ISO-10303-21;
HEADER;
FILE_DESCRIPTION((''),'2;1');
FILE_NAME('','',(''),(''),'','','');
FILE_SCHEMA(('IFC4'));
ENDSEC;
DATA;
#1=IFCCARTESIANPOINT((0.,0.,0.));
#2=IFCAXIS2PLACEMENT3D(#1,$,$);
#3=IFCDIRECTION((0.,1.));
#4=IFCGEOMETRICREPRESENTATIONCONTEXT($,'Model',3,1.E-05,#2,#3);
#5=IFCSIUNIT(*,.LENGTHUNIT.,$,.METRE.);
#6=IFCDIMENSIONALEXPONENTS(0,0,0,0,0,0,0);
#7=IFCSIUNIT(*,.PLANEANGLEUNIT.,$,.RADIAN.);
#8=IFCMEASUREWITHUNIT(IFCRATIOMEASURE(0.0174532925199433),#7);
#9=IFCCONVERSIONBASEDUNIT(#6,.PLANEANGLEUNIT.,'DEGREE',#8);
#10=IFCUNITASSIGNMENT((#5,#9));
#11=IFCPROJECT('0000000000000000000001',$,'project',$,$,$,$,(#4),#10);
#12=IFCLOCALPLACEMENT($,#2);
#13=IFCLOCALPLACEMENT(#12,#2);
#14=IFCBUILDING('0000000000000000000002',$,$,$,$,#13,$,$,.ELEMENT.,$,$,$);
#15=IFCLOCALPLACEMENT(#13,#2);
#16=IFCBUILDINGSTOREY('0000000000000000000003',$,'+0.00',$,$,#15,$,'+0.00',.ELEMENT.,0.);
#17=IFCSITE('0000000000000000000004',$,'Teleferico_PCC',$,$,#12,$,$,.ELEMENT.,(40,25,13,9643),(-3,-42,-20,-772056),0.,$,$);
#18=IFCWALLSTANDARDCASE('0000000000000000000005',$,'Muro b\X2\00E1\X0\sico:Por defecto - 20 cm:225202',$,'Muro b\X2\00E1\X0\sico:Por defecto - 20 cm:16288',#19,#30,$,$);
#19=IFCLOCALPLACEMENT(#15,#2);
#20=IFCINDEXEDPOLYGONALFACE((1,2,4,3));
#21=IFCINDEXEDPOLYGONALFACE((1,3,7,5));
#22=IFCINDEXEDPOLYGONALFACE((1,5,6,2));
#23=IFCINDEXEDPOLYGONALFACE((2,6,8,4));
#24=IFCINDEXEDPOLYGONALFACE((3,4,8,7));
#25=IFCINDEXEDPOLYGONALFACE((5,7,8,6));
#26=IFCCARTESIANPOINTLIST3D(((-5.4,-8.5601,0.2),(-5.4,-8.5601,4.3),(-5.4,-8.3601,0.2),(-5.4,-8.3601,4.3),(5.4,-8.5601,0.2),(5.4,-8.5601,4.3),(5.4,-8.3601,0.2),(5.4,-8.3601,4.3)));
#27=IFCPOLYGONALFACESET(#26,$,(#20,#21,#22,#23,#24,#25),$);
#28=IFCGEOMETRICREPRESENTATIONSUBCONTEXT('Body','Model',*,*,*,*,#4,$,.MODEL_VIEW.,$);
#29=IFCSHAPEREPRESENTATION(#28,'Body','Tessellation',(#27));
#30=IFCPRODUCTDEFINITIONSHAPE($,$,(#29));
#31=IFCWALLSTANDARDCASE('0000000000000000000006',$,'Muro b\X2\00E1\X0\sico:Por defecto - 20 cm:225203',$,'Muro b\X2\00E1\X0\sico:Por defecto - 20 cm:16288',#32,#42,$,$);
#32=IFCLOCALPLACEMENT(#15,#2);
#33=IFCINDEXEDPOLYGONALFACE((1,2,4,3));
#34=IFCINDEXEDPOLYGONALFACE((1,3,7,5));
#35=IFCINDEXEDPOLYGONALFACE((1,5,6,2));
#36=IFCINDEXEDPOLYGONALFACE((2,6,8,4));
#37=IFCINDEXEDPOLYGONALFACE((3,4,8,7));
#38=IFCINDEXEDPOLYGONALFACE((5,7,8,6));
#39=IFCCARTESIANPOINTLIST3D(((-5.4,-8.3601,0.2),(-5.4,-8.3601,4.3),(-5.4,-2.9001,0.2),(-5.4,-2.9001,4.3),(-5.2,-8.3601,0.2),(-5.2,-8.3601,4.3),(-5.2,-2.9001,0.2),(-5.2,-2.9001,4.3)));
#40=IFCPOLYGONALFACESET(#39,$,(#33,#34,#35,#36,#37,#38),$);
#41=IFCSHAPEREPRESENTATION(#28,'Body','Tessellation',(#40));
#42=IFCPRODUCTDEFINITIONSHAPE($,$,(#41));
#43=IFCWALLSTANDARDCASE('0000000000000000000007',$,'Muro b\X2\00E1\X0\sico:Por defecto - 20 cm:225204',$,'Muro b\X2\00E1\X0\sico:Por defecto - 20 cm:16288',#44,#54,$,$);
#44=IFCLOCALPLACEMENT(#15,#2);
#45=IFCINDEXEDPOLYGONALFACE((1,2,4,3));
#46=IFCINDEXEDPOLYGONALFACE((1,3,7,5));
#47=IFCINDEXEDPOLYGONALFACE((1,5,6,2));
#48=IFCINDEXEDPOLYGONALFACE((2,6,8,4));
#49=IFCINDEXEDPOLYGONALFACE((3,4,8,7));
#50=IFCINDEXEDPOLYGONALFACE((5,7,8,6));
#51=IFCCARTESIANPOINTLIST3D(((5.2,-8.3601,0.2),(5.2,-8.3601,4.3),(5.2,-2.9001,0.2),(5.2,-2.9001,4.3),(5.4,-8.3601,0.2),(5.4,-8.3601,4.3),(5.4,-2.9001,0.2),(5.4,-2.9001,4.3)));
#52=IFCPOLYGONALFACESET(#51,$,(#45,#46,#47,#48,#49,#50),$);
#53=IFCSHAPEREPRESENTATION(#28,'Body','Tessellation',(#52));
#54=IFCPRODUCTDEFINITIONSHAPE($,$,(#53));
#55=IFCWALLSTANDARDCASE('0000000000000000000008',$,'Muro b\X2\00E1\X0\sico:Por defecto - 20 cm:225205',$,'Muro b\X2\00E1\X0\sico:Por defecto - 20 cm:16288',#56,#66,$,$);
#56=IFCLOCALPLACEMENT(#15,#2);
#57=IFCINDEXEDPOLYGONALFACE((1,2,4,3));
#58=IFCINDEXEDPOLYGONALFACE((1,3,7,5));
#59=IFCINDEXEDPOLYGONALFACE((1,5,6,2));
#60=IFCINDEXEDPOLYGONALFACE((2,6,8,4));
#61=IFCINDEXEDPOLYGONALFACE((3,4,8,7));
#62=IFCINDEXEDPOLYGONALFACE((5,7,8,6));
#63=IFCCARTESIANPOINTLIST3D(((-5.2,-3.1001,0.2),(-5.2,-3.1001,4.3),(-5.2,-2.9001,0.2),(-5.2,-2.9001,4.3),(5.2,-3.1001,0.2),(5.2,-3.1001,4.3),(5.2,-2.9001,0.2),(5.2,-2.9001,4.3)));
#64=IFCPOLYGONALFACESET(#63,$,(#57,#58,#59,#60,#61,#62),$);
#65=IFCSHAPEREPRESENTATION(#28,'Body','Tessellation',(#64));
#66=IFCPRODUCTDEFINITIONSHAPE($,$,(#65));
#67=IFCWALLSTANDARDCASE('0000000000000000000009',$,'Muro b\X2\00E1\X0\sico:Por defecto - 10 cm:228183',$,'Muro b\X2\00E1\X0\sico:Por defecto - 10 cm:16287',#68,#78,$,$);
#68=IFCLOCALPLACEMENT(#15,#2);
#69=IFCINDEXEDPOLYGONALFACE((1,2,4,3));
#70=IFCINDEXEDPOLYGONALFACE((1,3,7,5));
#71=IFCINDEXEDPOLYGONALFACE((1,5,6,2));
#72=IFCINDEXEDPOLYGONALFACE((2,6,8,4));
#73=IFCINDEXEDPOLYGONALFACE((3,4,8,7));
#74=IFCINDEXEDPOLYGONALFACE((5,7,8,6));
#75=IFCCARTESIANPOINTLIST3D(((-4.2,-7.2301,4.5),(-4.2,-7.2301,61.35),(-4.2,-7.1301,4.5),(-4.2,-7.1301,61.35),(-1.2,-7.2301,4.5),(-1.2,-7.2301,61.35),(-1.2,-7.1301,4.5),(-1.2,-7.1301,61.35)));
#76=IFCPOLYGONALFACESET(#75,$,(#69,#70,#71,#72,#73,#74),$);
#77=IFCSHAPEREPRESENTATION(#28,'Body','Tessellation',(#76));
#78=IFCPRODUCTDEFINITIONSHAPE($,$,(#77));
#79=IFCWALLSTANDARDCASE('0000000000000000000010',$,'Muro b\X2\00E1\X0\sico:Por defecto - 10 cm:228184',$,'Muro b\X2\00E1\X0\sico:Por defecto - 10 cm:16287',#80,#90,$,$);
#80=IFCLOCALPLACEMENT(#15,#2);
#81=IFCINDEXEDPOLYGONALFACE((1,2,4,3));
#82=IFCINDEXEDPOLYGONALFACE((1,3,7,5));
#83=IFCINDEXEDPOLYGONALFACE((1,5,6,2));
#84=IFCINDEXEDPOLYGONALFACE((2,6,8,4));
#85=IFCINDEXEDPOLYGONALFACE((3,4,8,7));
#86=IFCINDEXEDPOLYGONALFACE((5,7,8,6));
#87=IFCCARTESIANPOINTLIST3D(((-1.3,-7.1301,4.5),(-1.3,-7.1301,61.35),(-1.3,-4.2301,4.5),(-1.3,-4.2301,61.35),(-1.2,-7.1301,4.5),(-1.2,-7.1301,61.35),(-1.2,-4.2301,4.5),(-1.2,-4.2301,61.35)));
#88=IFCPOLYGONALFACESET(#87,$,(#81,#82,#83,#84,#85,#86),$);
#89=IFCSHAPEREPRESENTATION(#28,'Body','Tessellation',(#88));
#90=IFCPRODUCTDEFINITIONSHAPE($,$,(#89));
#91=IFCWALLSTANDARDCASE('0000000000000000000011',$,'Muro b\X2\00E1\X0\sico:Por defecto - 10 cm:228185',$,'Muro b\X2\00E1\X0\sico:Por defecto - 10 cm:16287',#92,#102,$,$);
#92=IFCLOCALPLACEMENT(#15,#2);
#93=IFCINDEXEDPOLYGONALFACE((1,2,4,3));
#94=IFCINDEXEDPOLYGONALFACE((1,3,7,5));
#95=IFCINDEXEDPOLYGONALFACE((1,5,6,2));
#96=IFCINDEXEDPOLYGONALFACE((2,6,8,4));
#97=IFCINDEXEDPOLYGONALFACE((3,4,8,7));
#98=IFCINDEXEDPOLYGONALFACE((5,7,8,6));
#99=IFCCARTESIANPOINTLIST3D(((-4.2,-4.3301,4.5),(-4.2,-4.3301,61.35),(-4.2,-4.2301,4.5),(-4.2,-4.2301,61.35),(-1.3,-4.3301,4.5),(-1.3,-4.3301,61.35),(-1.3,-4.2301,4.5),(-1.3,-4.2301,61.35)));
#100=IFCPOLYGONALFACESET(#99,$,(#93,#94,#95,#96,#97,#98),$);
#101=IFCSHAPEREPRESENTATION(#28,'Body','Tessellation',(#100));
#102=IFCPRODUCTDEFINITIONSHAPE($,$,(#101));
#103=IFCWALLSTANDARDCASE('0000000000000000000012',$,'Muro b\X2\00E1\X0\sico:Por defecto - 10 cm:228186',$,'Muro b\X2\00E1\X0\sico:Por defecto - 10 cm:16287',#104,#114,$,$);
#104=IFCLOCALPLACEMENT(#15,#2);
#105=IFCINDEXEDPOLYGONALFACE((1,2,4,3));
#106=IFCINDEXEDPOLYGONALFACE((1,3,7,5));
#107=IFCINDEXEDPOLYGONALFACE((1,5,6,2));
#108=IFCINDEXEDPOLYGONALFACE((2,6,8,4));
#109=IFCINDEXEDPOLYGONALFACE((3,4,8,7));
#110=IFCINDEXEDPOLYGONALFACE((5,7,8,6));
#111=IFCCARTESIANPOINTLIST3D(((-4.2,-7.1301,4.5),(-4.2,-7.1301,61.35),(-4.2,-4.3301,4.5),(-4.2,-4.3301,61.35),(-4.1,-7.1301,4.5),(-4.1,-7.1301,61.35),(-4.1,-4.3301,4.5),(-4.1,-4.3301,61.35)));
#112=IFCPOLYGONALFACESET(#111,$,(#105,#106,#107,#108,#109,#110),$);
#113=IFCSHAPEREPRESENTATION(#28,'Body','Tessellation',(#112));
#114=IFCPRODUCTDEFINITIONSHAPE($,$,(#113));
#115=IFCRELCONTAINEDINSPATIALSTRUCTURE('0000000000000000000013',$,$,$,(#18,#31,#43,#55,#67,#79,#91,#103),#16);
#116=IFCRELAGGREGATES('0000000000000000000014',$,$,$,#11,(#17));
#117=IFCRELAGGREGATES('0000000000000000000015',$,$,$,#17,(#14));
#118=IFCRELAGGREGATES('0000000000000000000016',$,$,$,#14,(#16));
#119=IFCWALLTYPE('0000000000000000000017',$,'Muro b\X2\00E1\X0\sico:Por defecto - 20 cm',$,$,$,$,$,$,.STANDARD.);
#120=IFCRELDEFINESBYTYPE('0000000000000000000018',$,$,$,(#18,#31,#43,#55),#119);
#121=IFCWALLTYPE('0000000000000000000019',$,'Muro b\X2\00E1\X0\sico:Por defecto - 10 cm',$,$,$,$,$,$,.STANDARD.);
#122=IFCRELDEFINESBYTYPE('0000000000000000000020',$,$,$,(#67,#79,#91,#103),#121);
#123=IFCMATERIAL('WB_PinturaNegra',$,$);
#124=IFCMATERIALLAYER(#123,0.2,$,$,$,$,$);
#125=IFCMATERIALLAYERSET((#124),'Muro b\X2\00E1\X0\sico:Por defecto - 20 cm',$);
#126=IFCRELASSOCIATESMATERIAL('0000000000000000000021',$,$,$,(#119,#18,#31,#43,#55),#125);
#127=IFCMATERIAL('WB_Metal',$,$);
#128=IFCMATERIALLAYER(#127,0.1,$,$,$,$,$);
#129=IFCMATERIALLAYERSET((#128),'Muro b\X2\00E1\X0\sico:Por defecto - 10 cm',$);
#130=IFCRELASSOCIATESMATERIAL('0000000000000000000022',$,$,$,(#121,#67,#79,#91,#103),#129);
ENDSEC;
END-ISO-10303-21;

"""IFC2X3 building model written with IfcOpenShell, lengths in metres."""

from ifc_helpers import new_model, entity, si_unit, converted_unit, direction, frame, frame_2d, origin, place, context, subcontext, project, spatial, polyline, rectangle, extrude, clip, bounded_halfspace, material, layer, layer_set, layer_usage, type_object, element, save


model = new_model("IFC2X3")

# Units and contexts
model_context = context("Model", 3, precision=1e-05, world=origin(), true_north=direction((0.0, 1.0)))
body_context = subcontext(model_context, "Body", "Model", "MODEL_VIEW")
ifc_project = project(units=[si_unit("LENGTHUNIT", "METRE"), converted_unit("PLANEANGLEUNIT", "DEGREE", entity("IfcRatioMeasure", 0.0174532925199433), si_unit("PLANEANGLEUNIT", "RADIAN"), dimensions=[0, 0, 0, 0, 0, 0, 0])], contexts=[model_context])

# Site, building, storey
site_placement = place(None, origin())
site = spatial("IfcSite", under=ifc_project, at=site_placement, Name="Teleferico_PCC", CompositionType="ELEMENT", RefLatitude=(40, 25, 13, 9643), RefLongitude=(-3, -42, -20, -772056), RefElevation=0.0)
building_placement = place(site_placement, origin())
building = spatial("IfcBuilding", under=site, at=building_placement, CompositionType="ELEMENT")
storey_placement = place(building_placement, origin())
storey = spatial("IfcBuildingStorey", under=building, at=storey_placement, Name="+0.00", LongName="+0.00", CompositionType="ELEMENT", Elevation=0.0)

# Shared definitions
ifc_material_1 = material(Name="WB_Metal")

# Shared definitions
ifc_material_2 = material(Name="WB_PinturaNegra")

# Walls
ifc_layer_1 = layer(ifc_material_2, 0.2)
ifc_layer_set_1 = layer_set([ifc_layer_1], Name="Muro básico:Por defecto - 20 cm")
ifc_layer_usage_1 = layer_usage(ifc_layer_set_1, "AXIS2", "POSITIVE", -0.1)
wall_type_1 = type_object("IfcWallType", Name="Muro básico:Por defecto - 20 cm", PredefinedType="STANDARD", material=ifc_layer_set_1)
wall_1_placement = place(storey_placement, frame((-5.4, -8.4601, 0.2)))
element("IfcWallStandardCase", 1, at=wall_1_placement, inside=storey, type_object=wall_type_1, material=ifc_layer_usage_1, Name="Muro básico:Por defecto - 20 cm:225202", ObjectType="Muro básico:Por defecto - 20 cm:16288", context=body_context, shape_type="Clipping", body=[
    clip(clip(extrude(rectangle(XDim=10.8, YDim=0.2, at=frame_2d((5.4, 0.0), x_axis=(-1.0, 0.0))), origin(), (0.0, 0.0, 1.0), 4.1), bounded_halfspace(frame((0.0, -0.1, 4.1), z_axis=(0.0, 0.0, -1.0), x_axis=(0.0, -1.0, 0.0)), True, frame((0.0, -0.1, 4.1), z_axis=(0.0, 0.0, -1.0), x_axis=(0.0, -1.0, 0.0)), polyline([(0.0, 0.0), (-0.2, 0.0), (-0.2, -0.2), (-0.2, -10.6), (-0.2, -10.8), (0.0, -10.8), (0.0, 0.0)]))), bounded_halfspace(frame((10.8, -0.1, 0.0), z_axis=(0.0, 0.0, 1.0), x_axis=(0.0, 1.0, 0.0)), True, frame((10.8, -0.1, 0.0), z_axis=(0.0, 0.0, 1.0), x_axis=(0.0, 1.0, 0.0)), polyline([(0.0, 0.0), (0.2, 0.0), (0.2, 0.2), (0.2, 10.6), (0.2, 10.8), (0.0, 10.8), (0.0, 0.0)]))),
])
ifc_layer_usage_2 = layer_usage(ifc_layer_set_1, "AXIS2", "POSITIVE", -0.1)
wall_2_placement = place(storey_placement, frame((-5.3, -2.9001, 0.2), z_axis=(0.0, 0.0, 1.0), x_axis=(0.0, -1.0, 0.0)))
element("IfcWallStandardCase", 2, at=wall_2_placement, inside=storey, type_object=wall_type_1, material=ifc_layer_usage_2, Name="Muro básico:Por defecto - 20 cm:225203", ObjectType="Muro básico:Por defecto - 20 cm:16288", context=body_context, shape_type="Clipping", body=[
    clip(clip(extrude(rectangle(XDim=5.46, YDim=0.2, at=frame_2d((2.73, 0.0), x_axis=(-1.0, 0.0))), origin(), (0.0, 0.0, 1.0), 4.1), bounded_halfspace(frame((0.0, -0.1, 4.1), z_axis=(0.0, 0.0, -1.0), x_axis=(1.0, 0.0, 0.0)), True, frame((0.0, -0.1, 4.1), z_axis=(0.0, 0.0, -1.0), x_axis=(1.0, 0.0, 0.0)), polyline([(0.0, 0.0), (0.0, -0.2), (0.2, -0.2), (5.46, -0.2), (5.46, 0.0), (0.0, 0.0)]))), bounded_halfspace(frame((5.46, -0.1, 0.0), z_axis=(0.0, 0.0, 1.0), x_axis=(-1.0, 0.0, 0.0)), True, frame((5.46, -0.1, 0.0), z_axis=(0.0, 0.0, 1.0), x_axis=(-1.0, 0.0, 0.0)), polyline([(0.0, 0.0), (0.0, -0.2), (5.26, -0.2), (5.46, -0.2), (5.46, 0.0), (0.0, 0.0)]))),
])
ifc_layer_usage_3 = layer_usage(ifc_layer_set_1, "AXIS2", "POSITIVE", -0.1)
wall_3_placement = place(storey_placement, frame((5.3, -8.3601, 0.2), z_axis=(0.0, 0.0, 1.0), x_axis=(0.0, 1.0, 0.0)))
element("IfcWallStandardCase", 3, at=wall_3_placement, inside=storey, type_object=wall_type_1, material=ifc_layer_usage_3, Name="Muro básico:Por defecto - 20 cm:225204", ObjectType="Muro básico:Por defecto - 20 cm:16288", context=body_context, shape_type="Clipping", body=[
    clip(clip(extrude(rectangle(XDim=5.46, YDim=0.2, at=frame_2d((2.73, 0.0), x_axis=(-1.0, 0.0))), origin(), (0.0, 0.0, 1.0), 4.1), bounded_halfspace(frame((0.0, -0.1, 4.1), z_axis=(0.0, 0.0, -1.0), x_axis=(-1.0, 0.0, 0.0)), True, frame((0.0, -0.1, 4.1), z_axis=(0.0, 0.0, -1.0), x_axis=(-1.0, 0.0, 0.0)), polyline([(0.0, 0.0), (0.0, 0.2), (-5.26, 0.2), (-5.46, 0.2), (-5.46, 0.0), (0.0, 0.0)]))), bounded_halfspace(frame((5.46, -0.1, 0.0)), True, frame((5.46, -0.1, 0.0)), polyline([(0.0, 0.0), (0.0, 0.2), (-0.2, 0.2), (-5.46, 0.2), (-5.46, 0.0), (0.0, 0.0)]))),
])
ifc_layer_usage_4 = layer_usage(ifc_layer_set_1, "AXIS2", "POSITIVE", -0.1)
wall_4_placement = place(storey_placement, frame((5.2, -3.0001, 0.2), z_axis=(0.0, 0.0, 1.0), x_axis=(-1.0, 0.0, 0.0)))
element("IfcWallStandardCase", 4, at=wall_4_placement, inside=storey, type_object=wall_type_1, material=ifc_layer_usage_4, Name="Muro básico:Por defecto - 20 cm:225205", ObjectType="Muro básico:Por defecto - 20 cm:16288", context=body_context, shape_type="Clipping", body=[
    clip(clip(extrude(rectangle(XDim=10.4, YDim=0.2, at=frame_2d((5.2, 0.0), x_axis=(-1.0, 0.0))), origin(), (0.0, 0.0, 1.0), 4.1), bounded_halfspace(frame((0.0, -0.1, 4.1), z_axis=(0.0, 0.0, -1.0), x_axis=(0.0, 1.0, 0.0)), True, frame((0.0, -0.1, 4.1), z_axis=(0.0, 0.0, -1.0), x_axis=(0.0, 1.0, 0.0)), polyline([(0.0, 0.0), (0.2, 0.0), (0.2, 10.4), (0.0, 10.4), (0.0, 0.0)]))), bounded_halfspace(frame((10.4, -0.1, 0.0), z_axis=(0.0, 0.0, 1.0), x_axis=(0.0, -1.0, 0.0)), True, frame((10.4, -0.1, 0.0), z_axis=(0.0, 0.0, 1.0), x_axis=(0.0, -1.0, 0.0)), polyline([(0.0, 0.0), (-0.2, 0.0), (-0.2, -10.4), (0.0, -10.4), (0.0, 0.0)]))),
])
ifc_layer_2 = layer(ifc_material_1, 0.1)
ifc_layer_set_2 = layer_set([ifc_layer_2], Name="Muro básico:Por defecto - 10 cm")
ifc_layer_usage_5 = layer_usage(ifc_layer_set_2, "AXIS2", "POSITIVE", -0.05)
wall_type_2 = type_object("IfcWallType", Name="Muro básico:Por defecto - 10 cm", PredefinedType="STANDARD", material=ifc_layer_set_2)
wall_5_placement = place(storey_placement, frame((-4.2, -7.1801, 4.5)))
element("IfcWallStandardCase", 5, at=wall_5_placement, inside=storey, type_object=wall_type_2, material=ifc_layer_usage_5, Name="Muro básico:Por defecto - 10 cm:228183", ObjectType="Muro básico:Por defecto - 10 cm:16287", context=body_context, shape_type="Clipping", body=[
    clip(extrude(rectangle(XDim=3.0, YDim=0.1, at=frame_2d((1.5, 0.0), x_axis=(-1.0, 0.0))), origin(), (0.0, 0.0, 1.0), 56.85), bounded_halfspace(frame((0.0, -0.05, 56.85), z_axis=(0.0, 0.0, -1.0), x_axis=(1.0, 0.0, 0.0)), True, frame((0.0, -0.05, 56.85)), polyline([(0.0, 0.0), (0.15, 0.0), (2.85, 0.0), (3.0, 0.0), (3.0, 0.1), (2.9, 0.1), (2.85, 0.1), (0.15, 0.1), (0.1, 0.1), (0.0, 0.1), (0.0, 0.0)]))),
])
ifc_layer_usage_6 = layer_usage(ifc_layer_set_2, "AXIS2", "POSITIVE", -0.05)
wall_6_placement = place(storey_placement, frame((-1.25, -7.1301, 4.5), z_axis=(0.0, 0.0, 1.0), x_axis=(0.0, 1.0, 0.0)))
element("IfcWallStandardCase", 6, at=wall_6_placement, inside=storey, type_object=wall_type_2, material=ifc_layer_usage_6, Name="Muro básico:Por defecto - 10 cm:228184", ObjectType="Muro básico:Por defecto - 10 cm:16287", context=body_context, shape_type="Clipping", body=[
    clip(extrude(rectangle(XDim=2.9, YDim=0.1, at=frame_2d((1.45, 0.0), x_axis=(-1.0, 0.0))), origin(), (0.0, 0.0, 1.0), 56.85), bounded_halfspace(frame((0.0, -0.05, 56.85), z_axis=(0.0, 0.0, -1.0), x_axis=(0.0, -1.0, 0.0)), True, frame((0.0, -0.05, 56.85)), polyline([(0.0, 0.0), (0.05, 0.0), (2.75, 0.0), (2.9, 0.0), (2.9, 0.1), (2.8, 0.1), (2.75, 0.1), (0.05, 0.1), (0.0, 0.1), (0.0, 0.0)]))),
])
ifc_layer_usage_7 = layer_usage(ifc_layer_set_2, "AXIS2", "POSITIVE", -0.05)
wall_7_placement = place(storey_placement, frame((-1.3, -4.2801, 4.5), z_axis=(0.0, 0.0, 1.0), x_axis=(-1.0, 0.0, 0.0)))
element("IfcWallStandardCase", 7, at=wall_7_placement, inside=storey, type_object=wall_type_2, material=ifc_layer_usage_7, Name="Muro básico:Por defecto - 10 cm:228185", ObjectType="Muro básico:Por defecto - 10 cm:16287", context=body_context, shape_type="Clipping", body=[
    clip(extrude(rectangle(XDim=2.9, YDim=0.1, at=frame_2d((1.45, 0.0), x_axis=(-1.0, 0.0))), origin(), (0.0, 0.0, 1.0), 56.85), bounded_halfspace(frame((0.0, -0.05, 56.85), z_axis=(0.0, 0.0, -1.0), x_axis=(-1.0, 0.0, 0.0)), True, frame((0.0, -0.05, 56.85)), polyline([(0.0, 0.0), (0.05, 0.0), (2.75, 0.0), (2.9, 0.0), (2.9, 0.1), (2.8, 0.1), (2.75, 0.1), (0.05, 0.1), (0.0, 0.1), (0.0, 0.0)]))),
])
ifc_layer_usage_8 = layer_usage(ifc_layer_set_2, "AXIS2", "POSITIVE", -0.05)
wall_8_placement = place(storey_placement, frame((-4.15, -4.3301, 4.5), z_axis=(0.0, 0.0, 1.0), x_axis=(0.0, -1.0, 0.0)))
element("IfcWallStandardCase", 8, at=wall_8_placement, inside=storey, type_object=wall_type_2, material=ifc_layer_usage_8, Name="Muro básico:Por defecto - 10 cm:228186", ObjectType="Muro básico:Por defecto - 10 cm:16287", context=body_context, shape_type="Clipping", body=[
    clip(extrude(rectangle(XDim=2.8, YDim=0.1, at=frame_2d((1.4, 0.0), x_axis=(-1.0, 0.0))), origin(), (0.0, 0.0, 1.0), 56.85), bounded_halfspace(frame((0.0, -0.05, 56.85), z_axis=(0.0, 0.0, -1.0), x_axis=(0.0, 1.0, 0.0)), True, frame((0.0, -0.05, 56.85)), polyline([(0.0, 0.0), (0.05, 0.0), (2.75, 0.0), (2.8, 0.0), (2.8, 0.1), (2.75, 0.1), (0.05, 0.1), (0.0, 0.1), (0.0, 0.0)]))),
])

save(model, "model.ifc")
